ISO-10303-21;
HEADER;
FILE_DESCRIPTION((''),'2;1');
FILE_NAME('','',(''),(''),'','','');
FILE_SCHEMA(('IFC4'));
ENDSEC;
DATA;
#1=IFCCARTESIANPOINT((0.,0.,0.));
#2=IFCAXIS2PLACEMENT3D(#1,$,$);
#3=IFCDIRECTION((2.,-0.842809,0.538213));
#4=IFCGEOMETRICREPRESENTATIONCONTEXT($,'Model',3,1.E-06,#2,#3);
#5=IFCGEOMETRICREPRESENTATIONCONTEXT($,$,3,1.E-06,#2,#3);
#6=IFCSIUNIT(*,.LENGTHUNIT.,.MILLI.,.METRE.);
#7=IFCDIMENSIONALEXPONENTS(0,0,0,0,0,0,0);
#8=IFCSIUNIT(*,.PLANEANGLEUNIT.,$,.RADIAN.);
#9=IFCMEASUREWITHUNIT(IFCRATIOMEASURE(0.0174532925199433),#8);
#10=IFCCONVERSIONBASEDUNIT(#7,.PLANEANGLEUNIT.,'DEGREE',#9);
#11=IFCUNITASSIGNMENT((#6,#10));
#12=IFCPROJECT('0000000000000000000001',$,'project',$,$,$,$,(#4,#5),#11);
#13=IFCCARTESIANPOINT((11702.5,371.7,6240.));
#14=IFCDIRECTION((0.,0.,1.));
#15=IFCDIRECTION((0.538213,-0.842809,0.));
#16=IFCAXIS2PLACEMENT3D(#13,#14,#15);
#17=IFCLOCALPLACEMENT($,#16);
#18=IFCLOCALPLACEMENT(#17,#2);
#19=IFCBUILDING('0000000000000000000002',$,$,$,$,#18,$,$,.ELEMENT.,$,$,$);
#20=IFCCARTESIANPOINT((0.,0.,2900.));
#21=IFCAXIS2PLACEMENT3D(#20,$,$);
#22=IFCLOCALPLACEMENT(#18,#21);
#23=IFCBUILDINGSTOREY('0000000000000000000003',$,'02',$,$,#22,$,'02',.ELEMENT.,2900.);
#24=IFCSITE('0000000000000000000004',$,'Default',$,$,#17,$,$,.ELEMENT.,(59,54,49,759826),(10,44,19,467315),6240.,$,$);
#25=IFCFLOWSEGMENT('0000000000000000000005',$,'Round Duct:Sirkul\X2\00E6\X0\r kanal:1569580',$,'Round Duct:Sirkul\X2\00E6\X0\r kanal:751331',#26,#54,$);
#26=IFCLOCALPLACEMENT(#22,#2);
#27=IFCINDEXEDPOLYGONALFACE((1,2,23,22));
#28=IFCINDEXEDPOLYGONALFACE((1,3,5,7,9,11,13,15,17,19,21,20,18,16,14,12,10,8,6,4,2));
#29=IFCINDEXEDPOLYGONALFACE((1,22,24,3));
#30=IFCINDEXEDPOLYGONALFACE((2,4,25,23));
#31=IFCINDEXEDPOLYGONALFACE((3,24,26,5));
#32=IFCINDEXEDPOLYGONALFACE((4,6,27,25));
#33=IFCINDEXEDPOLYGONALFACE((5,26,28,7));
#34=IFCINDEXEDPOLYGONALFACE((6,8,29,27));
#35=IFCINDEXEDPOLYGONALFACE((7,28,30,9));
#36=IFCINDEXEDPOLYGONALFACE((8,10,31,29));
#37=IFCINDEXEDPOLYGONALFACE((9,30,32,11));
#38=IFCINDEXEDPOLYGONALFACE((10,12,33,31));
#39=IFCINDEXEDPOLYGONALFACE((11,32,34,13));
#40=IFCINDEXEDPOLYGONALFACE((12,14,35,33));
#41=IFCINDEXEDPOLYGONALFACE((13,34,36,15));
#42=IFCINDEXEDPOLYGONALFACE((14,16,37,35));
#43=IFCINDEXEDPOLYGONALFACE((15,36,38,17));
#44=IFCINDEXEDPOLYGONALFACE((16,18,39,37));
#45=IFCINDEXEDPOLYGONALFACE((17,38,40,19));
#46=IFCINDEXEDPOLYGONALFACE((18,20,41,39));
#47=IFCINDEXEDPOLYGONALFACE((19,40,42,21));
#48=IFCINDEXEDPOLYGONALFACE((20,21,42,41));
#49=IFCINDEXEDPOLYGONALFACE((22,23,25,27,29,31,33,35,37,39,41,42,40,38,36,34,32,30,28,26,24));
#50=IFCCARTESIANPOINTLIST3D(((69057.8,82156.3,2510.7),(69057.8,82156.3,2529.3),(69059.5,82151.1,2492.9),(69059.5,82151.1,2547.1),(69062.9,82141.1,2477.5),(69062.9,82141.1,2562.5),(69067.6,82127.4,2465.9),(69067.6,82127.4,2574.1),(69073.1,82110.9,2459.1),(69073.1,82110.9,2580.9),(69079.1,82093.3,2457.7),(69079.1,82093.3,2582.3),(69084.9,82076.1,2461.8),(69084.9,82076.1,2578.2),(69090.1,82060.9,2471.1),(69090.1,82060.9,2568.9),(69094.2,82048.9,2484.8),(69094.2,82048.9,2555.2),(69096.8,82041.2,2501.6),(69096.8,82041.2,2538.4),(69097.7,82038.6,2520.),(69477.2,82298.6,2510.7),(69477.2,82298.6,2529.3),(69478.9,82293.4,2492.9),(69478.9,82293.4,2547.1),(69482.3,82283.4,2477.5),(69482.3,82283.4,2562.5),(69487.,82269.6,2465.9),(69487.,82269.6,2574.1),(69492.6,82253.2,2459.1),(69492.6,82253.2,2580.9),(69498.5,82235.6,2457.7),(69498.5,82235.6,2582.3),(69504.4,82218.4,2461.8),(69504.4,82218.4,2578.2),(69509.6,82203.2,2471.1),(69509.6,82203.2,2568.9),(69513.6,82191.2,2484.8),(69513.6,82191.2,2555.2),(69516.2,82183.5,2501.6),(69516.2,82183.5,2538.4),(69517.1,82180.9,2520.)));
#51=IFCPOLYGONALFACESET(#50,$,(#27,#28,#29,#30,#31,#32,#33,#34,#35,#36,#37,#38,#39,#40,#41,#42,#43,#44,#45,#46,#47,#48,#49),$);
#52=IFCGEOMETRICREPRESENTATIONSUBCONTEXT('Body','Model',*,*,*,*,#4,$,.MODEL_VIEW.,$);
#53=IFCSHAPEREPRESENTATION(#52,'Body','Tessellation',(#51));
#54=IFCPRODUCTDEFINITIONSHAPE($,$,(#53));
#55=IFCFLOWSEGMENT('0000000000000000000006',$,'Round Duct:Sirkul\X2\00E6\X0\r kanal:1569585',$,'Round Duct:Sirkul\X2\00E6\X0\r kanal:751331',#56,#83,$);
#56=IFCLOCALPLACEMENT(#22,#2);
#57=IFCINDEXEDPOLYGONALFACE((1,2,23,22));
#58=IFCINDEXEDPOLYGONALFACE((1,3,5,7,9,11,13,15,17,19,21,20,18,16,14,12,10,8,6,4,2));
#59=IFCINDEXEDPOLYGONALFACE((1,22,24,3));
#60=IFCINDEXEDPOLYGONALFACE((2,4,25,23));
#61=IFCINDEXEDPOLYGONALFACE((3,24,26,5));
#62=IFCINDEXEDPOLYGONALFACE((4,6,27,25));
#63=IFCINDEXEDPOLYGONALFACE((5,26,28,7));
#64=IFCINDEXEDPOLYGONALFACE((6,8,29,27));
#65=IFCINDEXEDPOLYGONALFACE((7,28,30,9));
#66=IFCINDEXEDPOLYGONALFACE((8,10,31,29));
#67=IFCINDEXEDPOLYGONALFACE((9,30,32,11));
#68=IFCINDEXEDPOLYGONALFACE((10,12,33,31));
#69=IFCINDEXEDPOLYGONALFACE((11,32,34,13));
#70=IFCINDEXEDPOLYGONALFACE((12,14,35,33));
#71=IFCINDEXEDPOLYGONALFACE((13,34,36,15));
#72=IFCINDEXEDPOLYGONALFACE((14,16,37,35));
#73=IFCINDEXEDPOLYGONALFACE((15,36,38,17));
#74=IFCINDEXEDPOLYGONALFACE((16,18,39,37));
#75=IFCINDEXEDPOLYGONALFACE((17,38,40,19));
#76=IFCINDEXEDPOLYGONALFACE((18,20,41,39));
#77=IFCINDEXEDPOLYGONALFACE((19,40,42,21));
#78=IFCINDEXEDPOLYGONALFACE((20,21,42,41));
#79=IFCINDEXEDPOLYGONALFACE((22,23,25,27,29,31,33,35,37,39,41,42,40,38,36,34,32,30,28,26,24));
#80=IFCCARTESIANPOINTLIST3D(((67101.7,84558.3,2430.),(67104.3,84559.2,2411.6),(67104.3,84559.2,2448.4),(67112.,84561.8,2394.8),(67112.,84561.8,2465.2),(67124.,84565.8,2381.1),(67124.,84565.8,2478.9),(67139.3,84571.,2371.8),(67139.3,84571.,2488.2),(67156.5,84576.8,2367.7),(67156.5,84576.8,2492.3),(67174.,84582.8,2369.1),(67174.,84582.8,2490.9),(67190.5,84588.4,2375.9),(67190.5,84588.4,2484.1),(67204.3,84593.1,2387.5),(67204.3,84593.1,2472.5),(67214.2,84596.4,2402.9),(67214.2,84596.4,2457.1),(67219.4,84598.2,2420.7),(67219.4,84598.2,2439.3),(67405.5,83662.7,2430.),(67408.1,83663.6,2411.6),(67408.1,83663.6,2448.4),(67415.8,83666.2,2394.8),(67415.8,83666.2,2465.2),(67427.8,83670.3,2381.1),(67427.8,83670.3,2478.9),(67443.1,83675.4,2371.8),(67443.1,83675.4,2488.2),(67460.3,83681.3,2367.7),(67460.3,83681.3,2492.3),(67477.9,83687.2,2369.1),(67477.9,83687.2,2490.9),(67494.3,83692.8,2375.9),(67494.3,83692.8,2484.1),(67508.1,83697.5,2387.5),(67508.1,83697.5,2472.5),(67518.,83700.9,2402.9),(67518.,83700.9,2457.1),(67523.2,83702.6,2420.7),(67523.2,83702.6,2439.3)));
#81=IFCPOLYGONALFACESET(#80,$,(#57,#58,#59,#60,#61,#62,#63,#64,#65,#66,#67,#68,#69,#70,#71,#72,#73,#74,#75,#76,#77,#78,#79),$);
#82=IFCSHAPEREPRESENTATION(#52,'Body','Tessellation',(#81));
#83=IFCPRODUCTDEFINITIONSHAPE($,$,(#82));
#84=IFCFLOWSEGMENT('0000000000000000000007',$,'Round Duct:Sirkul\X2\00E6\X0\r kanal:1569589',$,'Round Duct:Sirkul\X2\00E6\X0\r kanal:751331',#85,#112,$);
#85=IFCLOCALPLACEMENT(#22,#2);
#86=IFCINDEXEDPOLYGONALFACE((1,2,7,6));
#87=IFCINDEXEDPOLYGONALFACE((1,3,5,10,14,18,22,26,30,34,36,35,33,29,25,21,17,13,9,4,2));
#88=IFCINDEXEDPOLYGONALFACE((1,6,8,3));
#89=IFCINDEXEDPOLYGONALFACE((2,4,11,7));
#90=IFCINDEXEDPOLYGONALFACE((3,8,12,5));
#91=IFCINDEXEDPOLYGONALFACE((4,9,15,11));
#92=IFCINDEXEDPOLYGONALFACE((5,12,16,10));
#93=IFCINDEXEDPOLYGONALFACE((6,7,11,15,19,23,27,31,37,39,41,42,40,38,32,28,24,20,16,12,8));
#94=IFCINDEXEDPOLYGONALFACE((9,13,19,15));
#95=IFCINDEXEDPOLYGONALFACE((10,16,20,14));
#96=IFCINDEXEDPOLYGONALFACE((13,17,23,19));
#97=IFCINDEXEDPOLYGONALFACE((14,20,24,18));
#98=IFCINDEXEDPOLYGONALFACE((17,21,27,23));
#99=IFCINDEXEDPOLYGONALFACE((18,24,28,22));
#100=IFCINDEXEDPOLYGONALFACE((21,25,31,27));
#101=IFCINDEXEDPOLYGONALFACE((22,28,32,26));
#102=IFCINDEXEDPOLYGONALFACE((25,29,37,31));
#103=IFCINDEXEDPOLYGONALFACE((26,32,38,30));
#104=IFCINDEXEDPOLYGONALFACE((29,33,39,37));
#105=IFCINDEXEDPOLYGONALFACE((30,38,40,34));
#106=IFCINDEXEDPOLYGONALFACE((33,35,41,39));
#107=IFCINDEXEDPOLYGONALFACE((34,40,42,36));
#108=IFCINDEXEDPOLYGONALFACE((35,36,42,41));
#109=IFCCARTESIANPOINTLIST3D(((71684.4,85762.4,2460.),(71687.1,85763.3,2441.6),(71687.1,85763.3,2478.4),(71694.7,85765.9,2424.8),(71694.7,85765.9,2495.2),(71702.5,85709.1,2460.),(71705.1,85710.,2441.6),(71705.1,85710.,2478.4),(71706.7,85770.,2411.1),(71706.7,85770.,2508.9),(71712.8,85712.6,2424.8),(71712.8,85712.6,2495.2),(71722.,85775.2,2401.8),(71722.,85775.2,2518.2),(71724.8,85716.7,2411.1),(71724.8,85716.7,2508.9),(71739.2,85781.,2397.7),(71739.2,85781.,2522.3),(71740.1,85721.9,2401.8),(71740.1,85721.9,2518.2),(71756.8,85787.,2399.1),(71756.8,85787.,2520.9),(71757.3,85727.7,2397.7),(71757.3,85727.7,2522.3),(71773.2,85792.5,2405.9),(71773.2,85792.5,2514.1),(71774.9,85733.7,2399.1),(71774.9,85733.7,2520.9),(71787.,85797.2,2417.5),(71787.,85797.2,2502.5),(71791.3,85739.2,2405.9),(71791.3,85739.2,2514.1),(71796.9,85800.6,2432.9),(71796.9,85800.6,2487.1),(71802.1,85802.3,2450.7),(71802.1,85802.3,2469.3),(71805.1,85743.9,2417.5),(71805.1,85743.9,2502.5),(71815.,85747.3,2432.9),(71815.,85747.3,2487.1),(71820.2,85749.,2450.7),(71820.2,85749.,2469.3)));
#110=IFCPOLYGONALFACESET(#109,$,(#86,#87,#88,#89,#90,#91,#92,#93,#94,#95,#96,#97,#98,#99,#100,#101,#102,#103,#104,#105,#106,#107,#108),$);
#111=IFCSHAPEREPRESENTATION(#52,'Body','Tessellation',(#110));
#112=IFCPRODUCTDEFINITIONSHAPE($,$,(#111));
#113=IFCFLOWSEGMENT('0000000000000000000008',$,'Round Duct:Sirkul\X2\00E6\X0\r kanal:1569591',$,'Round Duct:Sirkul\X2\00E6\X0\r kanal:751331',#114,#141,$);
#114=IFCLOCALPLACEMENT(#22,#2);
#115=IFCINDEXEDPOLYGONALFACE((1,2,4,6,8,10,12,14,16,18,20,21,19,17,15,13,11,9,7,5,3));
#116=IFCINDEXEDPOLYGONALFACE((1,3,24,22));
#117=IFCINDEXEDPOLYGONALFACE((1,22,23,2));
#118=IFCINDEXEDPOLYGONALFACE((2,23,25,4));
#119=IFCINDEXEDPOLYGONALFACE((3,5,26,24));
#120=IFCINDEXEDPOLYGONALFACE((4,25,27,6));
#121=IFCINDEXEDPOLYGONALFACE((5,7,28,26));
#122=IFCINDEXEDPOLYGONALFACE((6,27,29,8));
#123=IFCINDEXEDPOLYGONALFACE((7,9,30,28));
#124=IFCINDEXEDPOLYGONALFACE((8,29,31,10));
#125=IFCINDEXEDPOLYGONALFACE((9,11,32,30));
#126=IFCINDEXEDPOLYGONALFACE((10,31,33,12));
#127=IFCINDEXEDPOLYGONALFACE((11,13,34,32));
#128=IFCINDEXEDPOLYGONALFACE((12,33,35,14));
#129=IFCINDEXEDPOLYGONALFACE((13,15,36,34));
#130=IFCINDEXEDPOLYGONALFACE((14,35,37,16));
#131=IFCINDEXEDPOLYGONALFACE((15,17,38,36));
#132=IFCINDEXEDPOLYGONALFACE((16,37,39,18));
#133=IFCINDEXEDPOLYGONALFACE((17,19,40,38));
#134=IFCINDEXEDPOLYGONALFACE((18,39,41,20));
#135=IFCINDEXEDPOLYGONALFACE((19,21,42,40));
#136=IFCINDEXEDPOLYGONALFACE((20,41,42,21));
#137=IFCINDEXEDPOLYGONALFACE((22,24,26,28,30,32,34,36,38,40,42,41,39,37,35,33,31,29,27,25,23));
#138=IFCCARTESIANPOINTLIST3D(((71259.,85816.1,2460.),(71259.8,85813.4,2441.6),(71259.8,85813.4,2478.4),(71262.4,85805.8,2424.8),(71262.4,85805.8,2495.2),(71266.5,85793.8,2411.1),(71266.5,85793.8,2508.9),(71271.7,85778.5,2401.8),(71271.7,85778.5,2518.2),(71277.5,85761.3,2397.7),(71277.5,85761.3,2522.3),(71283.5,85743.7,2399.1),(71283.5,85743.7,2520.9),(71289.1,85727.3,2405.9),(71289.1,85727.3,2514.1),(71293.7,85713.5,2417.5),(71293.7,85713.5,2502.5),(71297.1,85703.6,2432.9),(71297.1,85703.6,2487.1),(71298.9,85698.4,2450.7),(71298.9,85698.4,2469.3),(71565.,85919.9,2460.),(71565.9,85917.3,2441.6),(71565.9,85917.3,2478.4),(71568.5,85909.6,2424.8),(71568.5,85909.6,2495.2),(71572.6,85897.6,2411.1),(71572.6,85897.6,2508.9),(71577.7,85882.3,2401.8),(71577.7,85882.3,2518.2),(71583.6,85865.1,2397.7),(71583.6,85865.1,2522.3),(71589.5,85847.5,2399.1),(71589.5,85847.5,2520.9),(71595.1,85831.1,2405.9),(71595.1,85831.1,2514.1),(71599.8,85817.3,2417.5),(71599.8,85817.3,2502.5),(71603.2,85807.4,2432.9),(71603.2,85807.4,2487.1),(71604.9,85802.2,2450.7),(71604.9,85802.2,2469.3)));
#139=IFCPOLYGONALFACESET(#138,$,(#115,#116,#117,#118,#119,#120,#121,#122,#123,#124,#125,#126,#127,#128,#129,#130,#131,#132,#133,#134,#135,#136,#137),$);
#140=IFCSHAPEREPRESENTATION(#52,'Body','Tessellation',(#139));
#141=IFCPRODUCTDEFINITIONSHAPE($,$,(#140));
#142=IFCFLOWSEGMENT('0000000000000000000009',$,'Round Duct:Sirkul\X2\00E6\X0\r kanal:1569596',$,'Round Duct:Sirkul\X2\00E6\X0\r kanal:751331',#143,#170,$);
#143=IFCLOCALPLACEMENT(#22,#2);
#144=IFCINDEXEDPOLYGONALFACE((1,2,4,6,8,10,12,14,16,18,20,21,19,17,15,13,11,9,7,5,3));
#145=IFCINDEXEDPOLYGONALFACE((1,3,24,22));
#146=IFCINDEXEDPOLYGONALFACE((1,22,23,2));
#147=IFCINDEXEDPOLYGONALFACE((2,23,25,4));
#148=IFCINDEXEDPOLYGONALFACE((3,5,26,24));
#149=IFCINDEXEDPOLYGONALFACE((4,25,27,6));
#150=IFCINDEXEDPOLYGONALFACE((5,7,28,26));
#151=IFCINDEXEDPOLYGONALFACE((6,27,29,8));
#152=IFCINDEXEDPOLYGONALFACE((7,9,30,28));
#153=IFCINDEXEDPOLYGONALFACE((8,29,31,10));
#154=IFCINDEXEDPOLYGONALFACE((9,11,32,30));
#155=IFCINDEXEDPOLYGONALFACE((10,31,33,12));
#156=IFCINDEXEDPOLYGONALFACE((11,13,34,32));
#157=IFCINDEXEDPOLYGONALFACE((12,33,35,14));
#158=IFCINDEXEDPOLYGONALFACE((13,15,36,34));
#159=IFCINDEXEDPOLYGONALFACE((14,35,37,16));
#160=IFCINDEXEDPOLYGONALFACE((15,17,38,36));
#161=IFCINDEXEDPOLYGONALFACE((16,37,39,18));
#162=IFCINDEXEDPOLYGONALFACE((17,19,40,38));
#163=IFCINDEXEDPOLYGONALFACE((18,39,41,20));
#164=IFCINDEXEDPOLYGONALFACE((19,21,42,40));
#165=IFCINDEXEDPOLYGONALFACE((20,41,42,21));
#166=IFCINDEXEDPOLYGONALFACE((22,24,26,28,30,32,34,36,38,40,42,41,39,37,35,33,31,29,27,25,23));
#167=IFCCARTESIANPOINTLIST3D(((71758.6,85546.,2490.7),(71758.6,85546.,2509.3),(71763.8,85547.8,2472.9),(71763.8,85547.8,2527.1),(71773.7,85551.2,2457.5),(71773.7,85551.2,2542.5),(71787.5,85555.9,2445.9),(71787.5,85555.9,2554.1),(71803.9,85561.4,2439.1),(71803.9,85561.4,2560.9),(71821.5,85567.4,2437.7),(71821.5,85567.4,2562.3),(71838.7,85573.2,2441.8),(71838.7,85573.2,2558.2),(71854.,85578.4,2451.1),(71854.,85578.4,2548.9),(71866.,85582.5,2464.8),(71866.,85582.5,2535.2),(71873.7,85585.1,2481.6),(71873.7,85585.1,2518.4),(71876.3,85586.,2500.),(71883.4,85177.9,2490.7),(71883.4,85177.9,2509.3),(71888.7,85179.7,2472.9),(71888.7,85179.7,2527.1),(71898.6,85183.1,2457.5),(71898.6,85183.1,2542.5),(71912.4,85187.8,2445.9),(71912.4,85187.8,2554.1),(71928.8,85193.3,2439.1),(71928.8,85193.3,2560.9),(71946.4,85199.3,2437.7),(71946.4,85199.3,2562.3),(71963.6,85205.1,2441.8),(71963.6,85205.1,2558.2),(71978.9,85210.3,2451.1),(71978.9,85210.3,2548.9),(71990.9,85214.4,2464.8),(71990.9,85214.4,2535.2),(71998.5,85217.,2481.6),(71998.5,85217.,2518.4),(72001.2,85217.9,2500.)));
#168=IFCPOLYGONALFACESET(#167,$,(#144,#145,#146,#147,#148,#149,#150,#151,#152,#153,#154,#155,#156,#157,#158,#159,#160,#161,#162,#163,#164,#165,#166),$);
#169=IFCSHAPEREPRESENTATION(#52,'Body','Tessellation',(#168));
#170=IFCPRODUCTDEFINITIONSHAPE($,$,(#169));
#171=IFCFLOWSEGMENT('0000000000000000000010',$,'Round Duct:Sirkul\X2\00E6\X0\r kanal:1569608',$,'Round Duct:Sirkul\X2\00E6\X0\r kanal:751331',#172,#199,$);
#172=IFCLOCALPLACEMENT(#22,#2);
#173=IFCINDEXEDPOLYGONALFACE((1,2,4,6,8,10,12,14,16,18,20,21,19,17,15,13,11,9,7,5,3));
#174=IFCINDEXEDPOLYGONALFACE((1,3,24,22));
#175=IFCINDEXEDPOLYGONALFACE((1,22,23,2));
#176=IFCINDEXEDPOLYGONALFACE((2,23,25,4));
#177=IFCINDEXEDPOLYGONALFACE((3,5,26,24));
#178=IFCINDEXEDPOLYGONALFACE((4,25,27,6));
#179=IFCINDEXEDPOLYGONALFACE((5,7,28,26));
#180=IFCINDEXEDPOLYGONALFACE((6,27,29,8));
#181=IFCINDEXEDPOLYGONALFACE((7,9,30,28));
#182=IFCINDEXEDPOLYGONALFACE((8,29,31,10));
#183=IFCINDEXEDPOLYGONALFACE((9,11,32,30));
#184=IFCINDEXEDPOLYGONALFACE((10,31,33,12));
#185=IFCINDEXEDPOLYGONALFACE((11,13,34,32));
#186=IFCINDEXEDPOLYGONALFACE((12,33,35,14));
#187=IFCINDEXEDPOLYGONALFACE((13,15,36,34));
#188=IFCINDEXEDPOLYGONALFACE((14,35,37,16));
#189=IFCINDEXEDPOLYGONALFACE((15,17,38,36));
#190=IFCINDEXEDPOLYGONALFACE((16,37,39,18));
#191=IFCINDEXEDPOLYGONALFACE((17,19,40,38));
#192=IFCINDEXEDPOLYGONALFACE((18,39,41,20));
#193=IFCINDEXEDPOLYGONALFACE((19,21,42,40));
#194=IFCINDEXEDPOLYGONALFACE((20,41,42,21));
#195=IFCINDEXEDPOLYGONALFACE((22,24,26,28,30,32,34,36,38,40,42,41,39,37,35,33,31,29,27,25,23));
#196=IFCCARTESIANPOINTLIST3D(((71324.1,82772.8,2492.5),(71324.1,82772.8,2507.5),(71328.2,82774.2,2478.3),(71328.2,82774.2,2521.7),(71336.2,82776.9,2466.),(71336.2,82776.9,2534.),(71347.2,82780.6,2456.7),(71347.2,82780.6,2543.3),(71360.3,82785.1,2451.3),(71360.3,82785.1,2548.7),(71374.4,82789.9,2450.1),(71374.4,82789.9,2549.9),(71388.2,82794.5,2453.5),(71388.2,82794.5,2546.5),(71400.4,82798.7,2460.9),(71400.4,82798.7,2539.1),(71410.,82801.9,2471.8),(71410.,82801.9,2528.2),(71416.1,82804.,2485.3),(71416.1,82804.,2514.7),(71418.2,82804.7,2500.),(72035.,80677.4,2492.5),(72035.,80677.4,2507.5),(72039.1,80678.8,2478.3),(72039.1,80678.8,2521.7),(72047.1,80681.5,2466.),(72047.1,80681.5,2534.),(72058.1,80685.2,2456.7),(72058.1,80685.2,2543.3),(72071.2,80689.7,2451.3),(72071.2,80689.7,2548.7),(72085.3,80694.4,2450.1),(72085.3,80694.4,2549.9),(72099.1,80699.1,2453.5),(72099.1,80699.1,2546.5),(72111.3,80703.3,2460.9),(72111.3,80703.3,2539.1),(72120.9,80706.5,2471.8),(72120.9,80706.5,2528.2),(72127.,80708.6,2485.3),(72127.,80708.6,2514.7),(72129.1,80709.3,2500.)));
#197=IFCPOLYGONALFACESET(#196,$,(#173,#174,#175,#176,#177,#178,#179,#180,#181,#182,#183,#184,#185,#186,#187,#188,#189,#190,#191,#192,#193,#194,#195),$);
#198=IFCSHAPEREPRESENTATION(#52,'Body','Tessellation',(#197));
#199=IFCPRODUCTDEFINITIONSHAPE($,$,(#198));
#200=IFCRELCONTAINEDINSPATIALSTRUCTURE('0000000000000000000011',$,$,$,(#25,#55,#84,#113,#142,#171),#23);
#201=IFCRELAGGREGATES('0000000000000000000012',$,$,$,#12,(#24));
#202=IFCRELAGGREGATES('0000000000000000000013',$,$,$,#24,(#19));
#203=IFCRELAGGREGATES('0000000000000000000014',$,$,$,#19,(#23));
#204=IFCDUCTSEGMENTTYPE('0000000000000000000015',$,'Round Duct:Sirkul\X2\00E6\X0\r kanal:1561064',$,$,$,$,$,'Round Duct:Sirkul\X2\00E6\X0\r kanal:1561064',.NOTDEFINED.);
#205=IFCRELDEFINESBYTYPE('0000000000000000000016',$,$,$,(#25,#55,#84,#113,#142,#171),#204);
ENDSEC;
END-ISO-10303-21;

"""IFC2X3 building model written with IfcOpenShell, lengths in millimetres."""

from ifc_helpers import new_model, entity, si_unit, converted_unit, direction, frame, frame_2d, origin, origin_2d_with_axis, place, context, subcontext, project, spatial, circle, extrude, type_object, element, save


model = new_model("IFC2X3")

# Units and contexts
model_context = context("Model", 3, precision=1e-06, world=origin(), true_north=direction((2.0, -0.842809, 0.538213)))
context_of_model = context(None, 3, precision=1e-06, world=origin(), true_north=direction((2.0, -0.842809, 0.538213)))
body_context = subcontext(model_context, "Body", "Model", "MODEL_VIEW")
ifc_project = project(units=[si_unit("LENGTHUNIT", "METRE", prefix="MILLI"), converted_unit("PLANEANGLEUNIT", "DEGREE", entity("IfcRatioMeasure", 0.0174532925199433), si_unit("PLANEANGLEUNIT", "RADIAN"), dimensions=[0, 0, 0, 0, 0, 0, 0])], contexts=[model_context, context_of_model])

# Site, building, storey
site_placement = place(None, frame((11702.5, 371.7, 6240.0), z_axis=(0.0, 0.0, 1.0), x_axis=(0.538213, -0.842809, 0.0)))
site = spatial("IfcSite", under=ifc_project, at=site_placement, Name="Default", CompositionType="ELEMENT", RefLatitude=(59, 54, 49, 759826), RefLongitude=(10, 44, 19, 467315), RefElevation=6240.0)
building_placement = place(site_placement, origin())
building = spatial("IfcBuilding", under=site, at=building_placement, CompositionType="ELEMENT")
storey_placement = place(building_placement, frame((0.0, 0.0, 2900.0)))
storey = spatial("IfcBuildingStorey", under=building, at=storey_placement, Name="02", LongName="02", CompositionType="ELEMENT", Elevation=2900.0)

# Flow segments
duct_segment_type = type_object("IfcDuctSegmentType", Name="Round Duct:Sirkulær kanal:1561064", ElementType="Round Duct:Sirkulær kanal:1561064", PredefinedType="NOTDEFINED")
flow_segment_1_placement = place(storey_placement, origin())
element("IfcFlowSegment", 1, at=flow_segment_1_placement, inside=storey, type_object=duct_segment_type, Name="Round Duct:Sirkulær kanal:1569580", ObjectType="Round Duct:Sirkulær kanal:751331", context=body_context, shape_type="SweptSolid", body=[
    extrude(circle(Radius=62.5, at=origin_2d_with_axis()), frame((69077.6, 82097.8, 2520.0), z_axis=(0.946986, 0.321274, 0.0), x_axis=(0.321274, -0.946986, 0.0)), (0.0, 0.0, 1.0), 442.9),
])
flow_segment_2_placement = place(storey_placement, origin())
element("IfcFlowSegment", 2, at=flow_segment_2_placement, inside=storey, type_object=duct_segment_type, Name="Round Duct:Sirkulær kanal:1569585", ObjectType="Round Duct:Sirkulær kanal:751331", context=body_context, shape_type="SweptSolid", body=[
    extrude(circle(Radius=62.5, at=origin_2d_with_axis()), frame((67160.9, 84578.3, 2430.0), z_axis=(0.321274, -0.946986, 0.0), x_axis=(-0.946986, -0.321274, 0.0)), (0.0, 0.0, 1.0), 945.7),
])
flow_segment_3_placement = place(storey_placement, origin())
element("IfcFlowSegment", 3, at=flow_segment_3_placement, inside=storey, type_object=duct_segment_type, Name="Round Duct:Sirkulær kanal:1569589", ObjectType="Round Duct:Sirkulær kanal:751331", context=body_context, shape_type="SweptSolid", body=[
    extrude(circle(Radius=62.5, at=frame_2d((0.0, 0.0), x_axis=(1.0, 0.0))), frame((71743.6, 85782.5, 2460.0), z_axis=(0.321274, -0.946986, 0.0), x_axis=(-0.946986, -0.321274, 0.0)), (0.0, 0.0, 1.0), 56.3),
])
flow_segment_4_placement = place(storey_placement, origin())
element("IfcFlowSegment", 4, at=flow_segment_4_placement, inside=storey, type_object=duct_segment_type, Name="Round Duct:Sirkulær kanal:1569591", ObjectType="Round Duct:Sirkulær kanal:751331", context=body_context, shape_type="SweptSolid", body=[
    extrude(circle(Radius=62.5, at=origin_2d_with_axis()), frame((71279.0, 85756.9, 2460.0), z_axis=(0.946996, 0.321245, 0.0), x_axis=(-0.321245, 0.946996, 0.0)), (0.0, 0.0, 1.0), 323.2),
])
flow_segment_5_placement = place(storey_placement, origin())
element("IfcFlowSegment", 5, at=flow_segment_5_placement, inside=storey, type_object=duct_segment_type, Name="Round Duct:Sirkulær kanal:1569596", ObjectType="Round Duct:Sirkulær kanal:751331", context=body_context, shape_type="SweptSolid", body=[
    extrude(circle(Radius=62.5, at=origin_2d_with_axis()), frame((71817.1, 85565.9, 2500.0), z_axis=(0.321274, -0.946986, 0.0), x_axis=(0.946986, 0.321274, 0.0)), (0.0, 0.0, 1.0), 388.7),
])
flow_segment_6_placement = place(storey_placement, origin())
element("IfcFlowSegment", 6, at=flow_segment_6_placement, inside=storey, type_object=duct_segment_type, Name="Round Duct:Sirkulær kanal:1569608", ObjectType="Round Duct:Sirkulær kanal:751331", context=body_context, shape_type="SweptSolid", body=[
    extrude(circle(Radius=50.0, at=origin_2d_with_axis()), frame((71370.9, 82788.7, 2500.0), z_axis=(0.321274, -0.946986, 0.0), x_axis=(0.946986, 0.321274, 0.0)), (0.0, 0.0, 1.0), 2212.7),
])

save(model, "model.ifc")
